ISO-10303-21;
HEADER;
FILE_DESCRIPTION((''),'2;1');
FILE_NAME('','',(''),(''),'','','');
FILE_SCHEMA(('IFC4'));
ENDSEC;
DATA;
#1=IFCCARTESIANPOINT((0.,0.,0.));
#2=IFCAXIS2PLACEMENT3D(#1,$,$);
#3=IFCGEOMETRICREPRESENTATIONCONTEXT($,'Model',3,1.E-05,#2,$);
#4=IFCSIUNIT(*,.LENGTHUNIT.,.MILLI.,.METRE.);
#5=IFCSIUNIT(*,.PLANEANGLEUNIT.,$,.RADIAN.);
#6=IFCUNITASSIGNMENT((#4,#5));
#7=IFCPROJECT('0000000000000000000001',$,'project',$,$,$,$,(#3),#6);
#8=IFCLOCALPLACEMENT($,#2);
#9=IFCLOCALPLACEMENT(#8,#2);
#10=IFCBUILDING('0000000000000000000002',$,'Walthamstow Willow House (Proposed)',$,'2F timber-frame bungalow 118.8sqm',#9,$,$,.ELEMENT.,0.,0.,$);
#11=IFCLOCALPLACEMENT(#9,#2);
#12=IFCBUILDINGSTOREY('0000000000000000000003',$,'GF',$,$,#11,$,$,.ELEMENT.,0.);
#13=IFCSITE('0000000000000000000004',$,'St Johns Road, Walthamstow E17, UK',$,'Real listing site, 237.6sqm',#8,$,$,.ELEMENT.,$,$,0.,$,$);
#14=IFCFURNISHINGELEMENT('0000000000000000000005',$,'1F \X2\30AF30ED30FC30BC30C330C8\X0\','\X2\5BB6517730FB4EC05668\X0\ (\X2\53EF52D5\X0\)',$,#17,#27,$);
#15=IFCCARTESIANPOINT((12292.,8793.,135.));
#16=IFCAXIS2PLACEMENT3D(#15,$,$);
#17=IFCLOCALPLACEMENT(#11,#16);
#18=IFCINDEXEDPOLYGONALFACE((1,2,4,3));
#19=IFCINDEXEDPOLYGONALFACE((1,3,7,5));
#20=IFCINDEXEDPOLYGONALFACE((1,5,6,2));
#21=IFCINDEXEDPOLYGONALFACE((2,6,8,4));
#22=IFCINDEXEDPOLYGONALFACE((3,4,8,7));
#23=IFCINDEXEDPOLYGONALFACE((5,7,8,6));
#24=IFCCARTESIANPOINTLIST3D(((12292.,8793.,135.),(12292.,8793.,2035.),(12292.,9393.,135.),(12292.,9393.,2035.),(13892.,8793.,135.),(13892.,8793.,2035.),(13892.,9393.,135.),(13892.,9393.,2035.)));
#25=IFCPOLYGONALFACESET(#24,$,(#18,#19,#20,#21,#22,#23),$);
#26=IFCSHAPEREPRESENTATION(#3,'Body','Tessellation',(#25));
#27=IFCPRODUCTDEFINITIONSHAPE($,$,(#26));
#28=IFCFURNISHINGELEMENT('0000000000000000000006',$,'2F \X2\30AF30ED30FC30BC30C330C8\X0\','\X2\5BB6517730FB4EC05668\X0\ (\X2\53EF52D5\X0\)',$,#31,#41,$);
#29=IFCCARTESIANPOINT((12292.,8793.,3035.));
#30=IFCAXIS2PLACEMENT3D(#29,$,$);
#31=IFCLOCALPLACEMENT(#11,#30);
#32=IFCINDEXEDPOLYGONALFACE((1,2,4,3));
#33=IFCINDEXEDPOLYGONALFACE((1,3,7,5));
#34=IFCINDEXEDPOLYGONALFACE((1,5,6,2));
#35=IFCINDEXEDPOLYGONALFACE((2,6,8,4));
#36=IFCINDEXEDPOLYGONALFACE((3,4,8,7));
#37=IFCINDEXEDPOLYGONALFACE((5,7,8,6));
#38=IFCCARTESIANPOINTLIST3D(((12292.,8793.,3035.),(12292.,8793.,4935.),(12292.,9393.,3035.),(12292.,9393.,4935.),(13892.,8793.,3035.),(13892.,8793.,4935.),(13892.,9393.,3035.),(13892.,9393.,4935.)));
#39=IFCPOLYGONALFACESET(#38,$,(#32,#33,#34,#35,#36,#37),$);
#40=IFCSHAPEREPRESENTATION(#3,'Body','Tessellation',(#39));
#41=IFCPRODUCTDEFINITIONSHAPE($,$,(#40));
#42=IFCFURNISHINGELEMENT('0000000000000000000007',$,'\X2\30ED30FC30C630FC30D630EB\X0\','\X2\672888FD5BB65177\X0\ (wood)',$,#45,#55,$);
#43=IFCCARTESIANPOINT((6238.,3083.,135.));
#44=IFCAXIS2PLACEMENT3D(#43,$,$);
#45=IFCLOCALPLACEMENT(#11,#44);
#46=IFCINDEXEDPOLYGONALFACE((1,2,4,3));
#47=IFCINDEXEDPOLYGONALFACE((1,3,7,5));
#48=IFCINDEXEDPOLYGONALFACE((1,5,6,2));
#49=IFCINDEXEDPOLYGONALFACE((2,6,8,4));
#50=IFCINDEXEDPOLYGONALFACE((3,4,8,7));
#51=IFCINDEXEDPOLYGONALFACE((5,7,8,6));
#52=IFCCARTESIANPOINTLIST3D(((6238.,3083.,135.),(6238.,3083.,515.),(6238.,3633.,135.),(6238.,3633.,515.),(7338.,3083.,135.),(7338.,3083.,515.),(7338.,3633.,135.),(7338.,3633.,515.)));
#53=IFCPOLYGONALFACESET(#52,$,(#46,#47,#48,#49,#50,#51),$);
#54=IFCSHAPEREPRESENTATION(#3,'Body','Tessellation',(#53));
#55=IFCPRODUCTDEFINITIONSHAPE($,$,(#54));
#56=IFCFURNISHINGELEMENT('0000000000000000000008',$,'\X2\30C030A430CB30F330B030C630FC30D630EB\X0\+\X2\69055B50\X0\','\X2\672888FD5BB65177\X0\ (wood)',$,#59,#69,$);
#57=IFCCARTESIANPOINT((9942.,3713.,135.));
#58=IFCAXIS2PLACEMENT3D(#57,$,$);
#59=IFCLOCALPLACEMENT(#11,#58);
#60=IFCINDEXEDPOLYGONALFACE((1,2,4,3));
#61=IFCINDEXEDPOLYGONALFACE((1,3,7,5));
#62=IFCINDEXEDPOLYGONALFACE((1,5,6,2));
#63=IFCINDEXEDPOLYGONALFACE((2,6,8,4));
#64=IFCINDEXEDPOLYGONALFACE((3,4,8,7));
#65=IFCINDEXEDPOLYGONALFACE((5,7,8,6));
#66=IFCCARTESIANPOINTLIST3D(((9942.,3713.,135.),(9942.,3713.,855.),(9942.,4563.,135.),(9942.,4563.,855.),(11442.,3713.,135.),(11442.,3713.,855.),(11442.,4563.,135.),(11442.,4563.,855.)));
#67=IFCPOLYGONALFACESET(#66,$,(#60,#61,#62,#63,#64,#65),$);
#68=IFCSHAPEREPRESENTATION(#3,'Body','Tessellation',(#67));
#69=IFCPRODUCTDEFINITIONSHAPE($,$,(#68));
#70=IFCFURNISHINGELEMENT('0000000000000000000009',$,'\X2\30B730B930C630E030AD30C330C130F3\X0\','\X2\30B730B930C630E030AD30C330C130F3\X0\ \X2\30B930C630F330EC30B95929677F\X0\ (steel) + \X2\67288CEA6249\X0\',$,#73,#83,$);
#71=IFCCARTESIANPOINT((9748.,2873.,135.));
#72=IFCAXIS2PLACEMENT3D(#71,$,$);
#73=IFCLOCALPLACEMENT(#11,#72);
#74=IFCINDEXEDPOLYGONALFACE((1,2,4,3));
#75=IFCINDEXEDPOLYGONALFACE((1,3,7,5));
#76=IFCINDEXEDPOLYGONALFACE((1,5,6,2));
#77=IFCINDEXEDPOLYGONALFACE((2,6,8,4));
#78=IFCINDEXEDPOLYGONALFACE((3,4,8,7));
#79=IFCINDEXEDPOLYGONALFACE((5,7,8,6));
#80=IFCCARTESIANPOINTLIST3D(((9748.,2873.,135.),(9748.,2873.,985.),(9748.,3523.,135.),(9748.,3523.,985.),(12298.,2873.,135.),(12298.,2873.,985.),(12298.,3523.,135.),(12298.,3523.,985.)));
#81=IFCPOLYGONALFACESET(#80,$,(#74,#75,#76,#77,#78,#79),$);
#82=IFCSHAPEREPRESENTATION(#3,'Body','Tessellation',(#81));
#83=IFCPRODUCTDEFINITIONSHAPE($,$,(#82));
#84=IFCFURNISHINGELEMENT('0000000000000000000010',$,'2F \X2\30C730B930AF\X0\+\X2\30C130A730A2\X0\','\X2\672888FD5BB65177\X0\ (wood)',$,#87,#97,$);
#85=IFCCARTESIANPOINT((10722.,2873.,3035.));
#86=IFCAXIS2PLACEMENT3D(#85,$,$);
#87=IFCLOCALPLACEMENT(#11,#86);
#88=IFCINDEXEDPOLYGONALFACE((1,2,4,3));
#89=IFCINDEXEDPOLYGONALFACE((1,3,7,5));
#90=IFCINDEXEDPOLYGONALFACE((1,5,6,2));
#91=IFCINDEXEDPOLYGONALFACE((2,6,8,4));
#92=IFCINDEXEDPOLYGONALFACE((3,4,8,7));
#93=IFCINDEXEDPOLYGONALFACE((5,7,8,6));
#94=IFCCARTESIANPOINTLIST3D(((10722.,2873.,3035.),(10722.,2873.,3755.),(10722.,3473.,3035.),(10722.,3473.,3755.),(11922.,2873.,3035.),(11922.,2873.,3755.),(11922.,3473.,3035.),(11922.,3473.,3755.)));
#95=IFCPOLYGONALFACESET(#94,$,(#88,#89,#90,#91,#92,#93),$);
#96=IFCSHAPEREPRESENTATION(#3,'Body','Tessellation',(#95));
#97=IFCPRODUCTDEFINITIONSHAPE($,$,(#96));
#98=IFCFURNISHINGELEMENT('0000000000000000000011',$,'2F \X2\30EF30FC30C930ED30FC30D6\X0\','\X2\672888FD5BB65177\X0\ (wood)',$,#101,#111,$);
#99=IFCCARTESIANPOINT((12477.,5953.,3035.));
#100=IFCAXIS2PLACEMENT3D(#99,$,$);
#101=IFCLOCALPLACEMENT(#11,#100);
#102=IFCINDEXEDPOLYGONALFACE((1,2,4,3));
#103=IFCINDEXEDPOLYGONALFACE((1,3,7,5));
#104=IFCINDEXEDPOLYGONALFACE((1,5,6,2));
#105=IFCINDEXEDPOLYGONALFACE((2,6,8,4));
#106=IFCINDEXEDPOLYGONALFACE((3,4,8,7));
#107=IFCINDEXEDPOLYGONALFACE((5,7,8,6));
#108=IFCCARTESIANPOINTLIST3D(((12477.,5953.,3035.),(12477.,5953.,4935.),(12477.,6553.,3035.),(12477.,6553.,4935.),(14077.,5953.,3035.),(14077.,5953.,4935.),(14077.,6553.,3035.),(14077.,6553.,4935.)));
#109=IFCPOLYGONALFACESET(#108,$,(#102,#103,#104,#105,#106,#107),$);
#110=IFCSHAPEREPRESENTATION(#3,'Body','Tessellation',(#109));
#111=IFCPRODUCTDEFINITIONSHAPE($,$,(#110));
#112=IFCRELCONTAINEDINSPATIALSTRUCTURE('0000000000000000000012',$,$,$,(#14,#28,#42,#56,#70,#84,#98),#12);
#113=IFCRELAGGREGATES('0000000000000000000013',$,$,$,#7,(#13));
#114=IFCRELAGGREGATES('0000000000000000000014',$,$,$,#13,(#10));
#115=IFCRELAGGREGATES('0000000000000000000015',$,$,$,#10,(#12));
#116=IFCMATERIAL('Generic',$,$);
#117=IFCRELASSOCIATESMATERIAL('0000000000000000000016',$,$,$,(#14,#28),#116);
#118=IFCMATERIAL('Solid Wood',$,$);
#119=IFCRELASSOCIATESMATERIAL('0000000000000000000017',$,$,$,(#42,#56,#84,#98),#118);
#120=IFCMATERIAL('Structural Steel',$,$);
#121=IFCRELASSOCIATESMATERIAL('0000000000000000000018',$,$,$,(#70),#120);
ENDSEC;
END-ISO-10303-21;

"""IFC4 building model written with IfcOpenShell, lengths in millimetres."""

from ifc_helpers import new_model, si_unit, frame, frame_2d, origin, place, context, project, spatial, rectangle, extrude, material, element, save


model = new_model("IFC4")

# Units and contexts
model_context = context("Model", 3, precision=1e-05, world=origin())
ifc_project = project(units=[si_unit("LENGTHUNIT", "METRE", prefix="MILLI"), si_unit("PLANEANGLEUNIT", "RADIAN")], contexts=[model_context])

# Site, building, storey
site_placement = place(None, origin())
site = spatial("IfcSite", under=ifc_project, at=site_placement, Name="St Johns Road, Walthamstow E17, UK", ObjectType="Real listing site, 237.6sqm", CompositionType="ELEMENT", RefElevation=0.0)
building_placement = place(site_placement, origin())
building = spatial("IfcBuilding", under=site, at=building_placement, Name="Walthamstow Willow House (Proposed)", ObjectType="2F timber-frame bungalow 118.8sqm", CompositionType="ELEMENT", ElevationOfRefHeight=0.0, ElevationOfTerrain=0.0)
storey_placement = place(building_placement, origin())
storey = spatial("IfcBuildingStorey", under=building, at=storey_placement, Name="GF", CompositionType="ELEMENT", Elevation=0.0)

# Shared definitions
ifc_material_1 = material(Name="Solid Wood")

# Shared definitions
ifc_material_2 = material(Name="Generic")

# Furnishing elements
furnishing_1_placement = place(storey_placement, frame((12292.0, 8793.0, 135.0)))
element("IfcFurnishingElement", 1, at=furnishing_1_placement, inside=storey, material=ifc_material_2, Name="1F クローゼット", Description="家具・什器 (可動)", context=model_context, shape_type="SweptSolid", body=[
    extrude(rectangle(XDim=1600.0, YDim=600.0, at=frame_2d((800.0, 300.0))), frame((12292.0, 8793.0, 135.0)), (0.0, 0.0, 1.0), 1900.0),
])
furnishing_2_placement = place(storey_placement, frame((12292.0, 8793.0, 3035.0)))
element("IfcFurnishingElement", 2, at=furnishing_2_placement, inside=storey, material=ifc_material_2, Name="2F クローゼット", Description="家具・什器 (可動)", context=model_context, shape_type="SweptSolid", body=[
    extrude(rectangle(XDim=1600.0, YDim=600.0, at=frame_2d((800.0, 300.0))), frame((12292.0, 8793.0, 3035.0)), (0.0, 0.0, 1.0), 1900.0),
])
furnishing_3_placement = place(storey_placement, frame((6238.0, 3083.0, 135.0)))
element("IfcFurnishingElement", 3, at=furnishing_3_placement, inside=storey, material=ifc_material_1, Name="ローテーブル", Description="木製家具 (wood)", context=model_context, shape_type="SweptSolid", body=[
    extrude(rectangle(XDim=1100.0, YDim=550.0, at=frame_2d((550.0, 275.0))), frame((6238.0, 3083.0, 135.0)), (0.0, 0.0, 1.0), 380.0),
])
furnishing_4_placement = place(storey_placement, frame((9942.0, 3713.0, 135.0)))
element("IfcFurnishingElement", 4, at=furnishing_4_placement, inside=storey, material=ifc_material_1, Name="ダイニングテーブル+椅子", Description="木製家具 (wood)", context=model_context, shape_type="SweptSolid", body=[
    extrude(rectangle(XDim=1500.0, YDim=850.0, at=frame_2d((750.0, 425.0))), frame((9942.0, 3713.0, 135.0)), (0.0, 0.0, 1.0), 720.0),
])
ifc_material_3 = material(Name="Structural Steel")
furnishing_5_placement = place(storey_placement, frame((9748.0, 2873.0, 135.0)))
element("IfcFurnishingElement", 5, at=furnishing_5_placement, inside=storey, material=ifc_material_3, Name="システムキッチン", Description="システムキッチン ステンレス天板 (steel) + 木質扉", context=model_context, shape_type="SweptSolid", body=[
    extrude(rectangle(XDim=2550.0, YDim=650.0, at=frame_2d((1275.0, 325.0))), frame((9748.0, 2873.0, 135.0)), (0.0, 0.0, 1.0), 850.0),
])
furnishing_6_placement = place(storey_placement, frame((10722.0, 2873.0, 3035.0)))
element("IfcFurnishingElement", 6, at=furnishing_6_placement, inside=storey, material=ifc_material_1, Name="2F デスク+チェア", Description="木製家具 (wood)", context=model_context, shape_type="SweptSolid", body=[
    extrude(rectangle(XDim=1200.0, YDim=600.0, at=frame_2d((600.0, 300.0))), frame((10722.0, 2873.0, 3035.0)), (0.0, 0.0, 1.0), 720.0),
])
furnishing_7_placement = place(storey_placement, frame((12477.0, 5953.0, 3035.0)))
element("IfcFurnishingElement", 7, at=furnishing_7_placement, inside=storey, material=ifc_material_1, Name="2F ワードローブ", Description="木製家具 (wood)", context=model_context, shape_type="SweptSolid", body=[
    extrude(rectangle(XDim=1600.0, YDim=600.0, at=frame_2d((800.0, 300.0))), frame((12477.0, 5953.0, 3035.0)), (0.0, 0.0, 1.0), 1900.0),
])

save(model, "model.ifc")
